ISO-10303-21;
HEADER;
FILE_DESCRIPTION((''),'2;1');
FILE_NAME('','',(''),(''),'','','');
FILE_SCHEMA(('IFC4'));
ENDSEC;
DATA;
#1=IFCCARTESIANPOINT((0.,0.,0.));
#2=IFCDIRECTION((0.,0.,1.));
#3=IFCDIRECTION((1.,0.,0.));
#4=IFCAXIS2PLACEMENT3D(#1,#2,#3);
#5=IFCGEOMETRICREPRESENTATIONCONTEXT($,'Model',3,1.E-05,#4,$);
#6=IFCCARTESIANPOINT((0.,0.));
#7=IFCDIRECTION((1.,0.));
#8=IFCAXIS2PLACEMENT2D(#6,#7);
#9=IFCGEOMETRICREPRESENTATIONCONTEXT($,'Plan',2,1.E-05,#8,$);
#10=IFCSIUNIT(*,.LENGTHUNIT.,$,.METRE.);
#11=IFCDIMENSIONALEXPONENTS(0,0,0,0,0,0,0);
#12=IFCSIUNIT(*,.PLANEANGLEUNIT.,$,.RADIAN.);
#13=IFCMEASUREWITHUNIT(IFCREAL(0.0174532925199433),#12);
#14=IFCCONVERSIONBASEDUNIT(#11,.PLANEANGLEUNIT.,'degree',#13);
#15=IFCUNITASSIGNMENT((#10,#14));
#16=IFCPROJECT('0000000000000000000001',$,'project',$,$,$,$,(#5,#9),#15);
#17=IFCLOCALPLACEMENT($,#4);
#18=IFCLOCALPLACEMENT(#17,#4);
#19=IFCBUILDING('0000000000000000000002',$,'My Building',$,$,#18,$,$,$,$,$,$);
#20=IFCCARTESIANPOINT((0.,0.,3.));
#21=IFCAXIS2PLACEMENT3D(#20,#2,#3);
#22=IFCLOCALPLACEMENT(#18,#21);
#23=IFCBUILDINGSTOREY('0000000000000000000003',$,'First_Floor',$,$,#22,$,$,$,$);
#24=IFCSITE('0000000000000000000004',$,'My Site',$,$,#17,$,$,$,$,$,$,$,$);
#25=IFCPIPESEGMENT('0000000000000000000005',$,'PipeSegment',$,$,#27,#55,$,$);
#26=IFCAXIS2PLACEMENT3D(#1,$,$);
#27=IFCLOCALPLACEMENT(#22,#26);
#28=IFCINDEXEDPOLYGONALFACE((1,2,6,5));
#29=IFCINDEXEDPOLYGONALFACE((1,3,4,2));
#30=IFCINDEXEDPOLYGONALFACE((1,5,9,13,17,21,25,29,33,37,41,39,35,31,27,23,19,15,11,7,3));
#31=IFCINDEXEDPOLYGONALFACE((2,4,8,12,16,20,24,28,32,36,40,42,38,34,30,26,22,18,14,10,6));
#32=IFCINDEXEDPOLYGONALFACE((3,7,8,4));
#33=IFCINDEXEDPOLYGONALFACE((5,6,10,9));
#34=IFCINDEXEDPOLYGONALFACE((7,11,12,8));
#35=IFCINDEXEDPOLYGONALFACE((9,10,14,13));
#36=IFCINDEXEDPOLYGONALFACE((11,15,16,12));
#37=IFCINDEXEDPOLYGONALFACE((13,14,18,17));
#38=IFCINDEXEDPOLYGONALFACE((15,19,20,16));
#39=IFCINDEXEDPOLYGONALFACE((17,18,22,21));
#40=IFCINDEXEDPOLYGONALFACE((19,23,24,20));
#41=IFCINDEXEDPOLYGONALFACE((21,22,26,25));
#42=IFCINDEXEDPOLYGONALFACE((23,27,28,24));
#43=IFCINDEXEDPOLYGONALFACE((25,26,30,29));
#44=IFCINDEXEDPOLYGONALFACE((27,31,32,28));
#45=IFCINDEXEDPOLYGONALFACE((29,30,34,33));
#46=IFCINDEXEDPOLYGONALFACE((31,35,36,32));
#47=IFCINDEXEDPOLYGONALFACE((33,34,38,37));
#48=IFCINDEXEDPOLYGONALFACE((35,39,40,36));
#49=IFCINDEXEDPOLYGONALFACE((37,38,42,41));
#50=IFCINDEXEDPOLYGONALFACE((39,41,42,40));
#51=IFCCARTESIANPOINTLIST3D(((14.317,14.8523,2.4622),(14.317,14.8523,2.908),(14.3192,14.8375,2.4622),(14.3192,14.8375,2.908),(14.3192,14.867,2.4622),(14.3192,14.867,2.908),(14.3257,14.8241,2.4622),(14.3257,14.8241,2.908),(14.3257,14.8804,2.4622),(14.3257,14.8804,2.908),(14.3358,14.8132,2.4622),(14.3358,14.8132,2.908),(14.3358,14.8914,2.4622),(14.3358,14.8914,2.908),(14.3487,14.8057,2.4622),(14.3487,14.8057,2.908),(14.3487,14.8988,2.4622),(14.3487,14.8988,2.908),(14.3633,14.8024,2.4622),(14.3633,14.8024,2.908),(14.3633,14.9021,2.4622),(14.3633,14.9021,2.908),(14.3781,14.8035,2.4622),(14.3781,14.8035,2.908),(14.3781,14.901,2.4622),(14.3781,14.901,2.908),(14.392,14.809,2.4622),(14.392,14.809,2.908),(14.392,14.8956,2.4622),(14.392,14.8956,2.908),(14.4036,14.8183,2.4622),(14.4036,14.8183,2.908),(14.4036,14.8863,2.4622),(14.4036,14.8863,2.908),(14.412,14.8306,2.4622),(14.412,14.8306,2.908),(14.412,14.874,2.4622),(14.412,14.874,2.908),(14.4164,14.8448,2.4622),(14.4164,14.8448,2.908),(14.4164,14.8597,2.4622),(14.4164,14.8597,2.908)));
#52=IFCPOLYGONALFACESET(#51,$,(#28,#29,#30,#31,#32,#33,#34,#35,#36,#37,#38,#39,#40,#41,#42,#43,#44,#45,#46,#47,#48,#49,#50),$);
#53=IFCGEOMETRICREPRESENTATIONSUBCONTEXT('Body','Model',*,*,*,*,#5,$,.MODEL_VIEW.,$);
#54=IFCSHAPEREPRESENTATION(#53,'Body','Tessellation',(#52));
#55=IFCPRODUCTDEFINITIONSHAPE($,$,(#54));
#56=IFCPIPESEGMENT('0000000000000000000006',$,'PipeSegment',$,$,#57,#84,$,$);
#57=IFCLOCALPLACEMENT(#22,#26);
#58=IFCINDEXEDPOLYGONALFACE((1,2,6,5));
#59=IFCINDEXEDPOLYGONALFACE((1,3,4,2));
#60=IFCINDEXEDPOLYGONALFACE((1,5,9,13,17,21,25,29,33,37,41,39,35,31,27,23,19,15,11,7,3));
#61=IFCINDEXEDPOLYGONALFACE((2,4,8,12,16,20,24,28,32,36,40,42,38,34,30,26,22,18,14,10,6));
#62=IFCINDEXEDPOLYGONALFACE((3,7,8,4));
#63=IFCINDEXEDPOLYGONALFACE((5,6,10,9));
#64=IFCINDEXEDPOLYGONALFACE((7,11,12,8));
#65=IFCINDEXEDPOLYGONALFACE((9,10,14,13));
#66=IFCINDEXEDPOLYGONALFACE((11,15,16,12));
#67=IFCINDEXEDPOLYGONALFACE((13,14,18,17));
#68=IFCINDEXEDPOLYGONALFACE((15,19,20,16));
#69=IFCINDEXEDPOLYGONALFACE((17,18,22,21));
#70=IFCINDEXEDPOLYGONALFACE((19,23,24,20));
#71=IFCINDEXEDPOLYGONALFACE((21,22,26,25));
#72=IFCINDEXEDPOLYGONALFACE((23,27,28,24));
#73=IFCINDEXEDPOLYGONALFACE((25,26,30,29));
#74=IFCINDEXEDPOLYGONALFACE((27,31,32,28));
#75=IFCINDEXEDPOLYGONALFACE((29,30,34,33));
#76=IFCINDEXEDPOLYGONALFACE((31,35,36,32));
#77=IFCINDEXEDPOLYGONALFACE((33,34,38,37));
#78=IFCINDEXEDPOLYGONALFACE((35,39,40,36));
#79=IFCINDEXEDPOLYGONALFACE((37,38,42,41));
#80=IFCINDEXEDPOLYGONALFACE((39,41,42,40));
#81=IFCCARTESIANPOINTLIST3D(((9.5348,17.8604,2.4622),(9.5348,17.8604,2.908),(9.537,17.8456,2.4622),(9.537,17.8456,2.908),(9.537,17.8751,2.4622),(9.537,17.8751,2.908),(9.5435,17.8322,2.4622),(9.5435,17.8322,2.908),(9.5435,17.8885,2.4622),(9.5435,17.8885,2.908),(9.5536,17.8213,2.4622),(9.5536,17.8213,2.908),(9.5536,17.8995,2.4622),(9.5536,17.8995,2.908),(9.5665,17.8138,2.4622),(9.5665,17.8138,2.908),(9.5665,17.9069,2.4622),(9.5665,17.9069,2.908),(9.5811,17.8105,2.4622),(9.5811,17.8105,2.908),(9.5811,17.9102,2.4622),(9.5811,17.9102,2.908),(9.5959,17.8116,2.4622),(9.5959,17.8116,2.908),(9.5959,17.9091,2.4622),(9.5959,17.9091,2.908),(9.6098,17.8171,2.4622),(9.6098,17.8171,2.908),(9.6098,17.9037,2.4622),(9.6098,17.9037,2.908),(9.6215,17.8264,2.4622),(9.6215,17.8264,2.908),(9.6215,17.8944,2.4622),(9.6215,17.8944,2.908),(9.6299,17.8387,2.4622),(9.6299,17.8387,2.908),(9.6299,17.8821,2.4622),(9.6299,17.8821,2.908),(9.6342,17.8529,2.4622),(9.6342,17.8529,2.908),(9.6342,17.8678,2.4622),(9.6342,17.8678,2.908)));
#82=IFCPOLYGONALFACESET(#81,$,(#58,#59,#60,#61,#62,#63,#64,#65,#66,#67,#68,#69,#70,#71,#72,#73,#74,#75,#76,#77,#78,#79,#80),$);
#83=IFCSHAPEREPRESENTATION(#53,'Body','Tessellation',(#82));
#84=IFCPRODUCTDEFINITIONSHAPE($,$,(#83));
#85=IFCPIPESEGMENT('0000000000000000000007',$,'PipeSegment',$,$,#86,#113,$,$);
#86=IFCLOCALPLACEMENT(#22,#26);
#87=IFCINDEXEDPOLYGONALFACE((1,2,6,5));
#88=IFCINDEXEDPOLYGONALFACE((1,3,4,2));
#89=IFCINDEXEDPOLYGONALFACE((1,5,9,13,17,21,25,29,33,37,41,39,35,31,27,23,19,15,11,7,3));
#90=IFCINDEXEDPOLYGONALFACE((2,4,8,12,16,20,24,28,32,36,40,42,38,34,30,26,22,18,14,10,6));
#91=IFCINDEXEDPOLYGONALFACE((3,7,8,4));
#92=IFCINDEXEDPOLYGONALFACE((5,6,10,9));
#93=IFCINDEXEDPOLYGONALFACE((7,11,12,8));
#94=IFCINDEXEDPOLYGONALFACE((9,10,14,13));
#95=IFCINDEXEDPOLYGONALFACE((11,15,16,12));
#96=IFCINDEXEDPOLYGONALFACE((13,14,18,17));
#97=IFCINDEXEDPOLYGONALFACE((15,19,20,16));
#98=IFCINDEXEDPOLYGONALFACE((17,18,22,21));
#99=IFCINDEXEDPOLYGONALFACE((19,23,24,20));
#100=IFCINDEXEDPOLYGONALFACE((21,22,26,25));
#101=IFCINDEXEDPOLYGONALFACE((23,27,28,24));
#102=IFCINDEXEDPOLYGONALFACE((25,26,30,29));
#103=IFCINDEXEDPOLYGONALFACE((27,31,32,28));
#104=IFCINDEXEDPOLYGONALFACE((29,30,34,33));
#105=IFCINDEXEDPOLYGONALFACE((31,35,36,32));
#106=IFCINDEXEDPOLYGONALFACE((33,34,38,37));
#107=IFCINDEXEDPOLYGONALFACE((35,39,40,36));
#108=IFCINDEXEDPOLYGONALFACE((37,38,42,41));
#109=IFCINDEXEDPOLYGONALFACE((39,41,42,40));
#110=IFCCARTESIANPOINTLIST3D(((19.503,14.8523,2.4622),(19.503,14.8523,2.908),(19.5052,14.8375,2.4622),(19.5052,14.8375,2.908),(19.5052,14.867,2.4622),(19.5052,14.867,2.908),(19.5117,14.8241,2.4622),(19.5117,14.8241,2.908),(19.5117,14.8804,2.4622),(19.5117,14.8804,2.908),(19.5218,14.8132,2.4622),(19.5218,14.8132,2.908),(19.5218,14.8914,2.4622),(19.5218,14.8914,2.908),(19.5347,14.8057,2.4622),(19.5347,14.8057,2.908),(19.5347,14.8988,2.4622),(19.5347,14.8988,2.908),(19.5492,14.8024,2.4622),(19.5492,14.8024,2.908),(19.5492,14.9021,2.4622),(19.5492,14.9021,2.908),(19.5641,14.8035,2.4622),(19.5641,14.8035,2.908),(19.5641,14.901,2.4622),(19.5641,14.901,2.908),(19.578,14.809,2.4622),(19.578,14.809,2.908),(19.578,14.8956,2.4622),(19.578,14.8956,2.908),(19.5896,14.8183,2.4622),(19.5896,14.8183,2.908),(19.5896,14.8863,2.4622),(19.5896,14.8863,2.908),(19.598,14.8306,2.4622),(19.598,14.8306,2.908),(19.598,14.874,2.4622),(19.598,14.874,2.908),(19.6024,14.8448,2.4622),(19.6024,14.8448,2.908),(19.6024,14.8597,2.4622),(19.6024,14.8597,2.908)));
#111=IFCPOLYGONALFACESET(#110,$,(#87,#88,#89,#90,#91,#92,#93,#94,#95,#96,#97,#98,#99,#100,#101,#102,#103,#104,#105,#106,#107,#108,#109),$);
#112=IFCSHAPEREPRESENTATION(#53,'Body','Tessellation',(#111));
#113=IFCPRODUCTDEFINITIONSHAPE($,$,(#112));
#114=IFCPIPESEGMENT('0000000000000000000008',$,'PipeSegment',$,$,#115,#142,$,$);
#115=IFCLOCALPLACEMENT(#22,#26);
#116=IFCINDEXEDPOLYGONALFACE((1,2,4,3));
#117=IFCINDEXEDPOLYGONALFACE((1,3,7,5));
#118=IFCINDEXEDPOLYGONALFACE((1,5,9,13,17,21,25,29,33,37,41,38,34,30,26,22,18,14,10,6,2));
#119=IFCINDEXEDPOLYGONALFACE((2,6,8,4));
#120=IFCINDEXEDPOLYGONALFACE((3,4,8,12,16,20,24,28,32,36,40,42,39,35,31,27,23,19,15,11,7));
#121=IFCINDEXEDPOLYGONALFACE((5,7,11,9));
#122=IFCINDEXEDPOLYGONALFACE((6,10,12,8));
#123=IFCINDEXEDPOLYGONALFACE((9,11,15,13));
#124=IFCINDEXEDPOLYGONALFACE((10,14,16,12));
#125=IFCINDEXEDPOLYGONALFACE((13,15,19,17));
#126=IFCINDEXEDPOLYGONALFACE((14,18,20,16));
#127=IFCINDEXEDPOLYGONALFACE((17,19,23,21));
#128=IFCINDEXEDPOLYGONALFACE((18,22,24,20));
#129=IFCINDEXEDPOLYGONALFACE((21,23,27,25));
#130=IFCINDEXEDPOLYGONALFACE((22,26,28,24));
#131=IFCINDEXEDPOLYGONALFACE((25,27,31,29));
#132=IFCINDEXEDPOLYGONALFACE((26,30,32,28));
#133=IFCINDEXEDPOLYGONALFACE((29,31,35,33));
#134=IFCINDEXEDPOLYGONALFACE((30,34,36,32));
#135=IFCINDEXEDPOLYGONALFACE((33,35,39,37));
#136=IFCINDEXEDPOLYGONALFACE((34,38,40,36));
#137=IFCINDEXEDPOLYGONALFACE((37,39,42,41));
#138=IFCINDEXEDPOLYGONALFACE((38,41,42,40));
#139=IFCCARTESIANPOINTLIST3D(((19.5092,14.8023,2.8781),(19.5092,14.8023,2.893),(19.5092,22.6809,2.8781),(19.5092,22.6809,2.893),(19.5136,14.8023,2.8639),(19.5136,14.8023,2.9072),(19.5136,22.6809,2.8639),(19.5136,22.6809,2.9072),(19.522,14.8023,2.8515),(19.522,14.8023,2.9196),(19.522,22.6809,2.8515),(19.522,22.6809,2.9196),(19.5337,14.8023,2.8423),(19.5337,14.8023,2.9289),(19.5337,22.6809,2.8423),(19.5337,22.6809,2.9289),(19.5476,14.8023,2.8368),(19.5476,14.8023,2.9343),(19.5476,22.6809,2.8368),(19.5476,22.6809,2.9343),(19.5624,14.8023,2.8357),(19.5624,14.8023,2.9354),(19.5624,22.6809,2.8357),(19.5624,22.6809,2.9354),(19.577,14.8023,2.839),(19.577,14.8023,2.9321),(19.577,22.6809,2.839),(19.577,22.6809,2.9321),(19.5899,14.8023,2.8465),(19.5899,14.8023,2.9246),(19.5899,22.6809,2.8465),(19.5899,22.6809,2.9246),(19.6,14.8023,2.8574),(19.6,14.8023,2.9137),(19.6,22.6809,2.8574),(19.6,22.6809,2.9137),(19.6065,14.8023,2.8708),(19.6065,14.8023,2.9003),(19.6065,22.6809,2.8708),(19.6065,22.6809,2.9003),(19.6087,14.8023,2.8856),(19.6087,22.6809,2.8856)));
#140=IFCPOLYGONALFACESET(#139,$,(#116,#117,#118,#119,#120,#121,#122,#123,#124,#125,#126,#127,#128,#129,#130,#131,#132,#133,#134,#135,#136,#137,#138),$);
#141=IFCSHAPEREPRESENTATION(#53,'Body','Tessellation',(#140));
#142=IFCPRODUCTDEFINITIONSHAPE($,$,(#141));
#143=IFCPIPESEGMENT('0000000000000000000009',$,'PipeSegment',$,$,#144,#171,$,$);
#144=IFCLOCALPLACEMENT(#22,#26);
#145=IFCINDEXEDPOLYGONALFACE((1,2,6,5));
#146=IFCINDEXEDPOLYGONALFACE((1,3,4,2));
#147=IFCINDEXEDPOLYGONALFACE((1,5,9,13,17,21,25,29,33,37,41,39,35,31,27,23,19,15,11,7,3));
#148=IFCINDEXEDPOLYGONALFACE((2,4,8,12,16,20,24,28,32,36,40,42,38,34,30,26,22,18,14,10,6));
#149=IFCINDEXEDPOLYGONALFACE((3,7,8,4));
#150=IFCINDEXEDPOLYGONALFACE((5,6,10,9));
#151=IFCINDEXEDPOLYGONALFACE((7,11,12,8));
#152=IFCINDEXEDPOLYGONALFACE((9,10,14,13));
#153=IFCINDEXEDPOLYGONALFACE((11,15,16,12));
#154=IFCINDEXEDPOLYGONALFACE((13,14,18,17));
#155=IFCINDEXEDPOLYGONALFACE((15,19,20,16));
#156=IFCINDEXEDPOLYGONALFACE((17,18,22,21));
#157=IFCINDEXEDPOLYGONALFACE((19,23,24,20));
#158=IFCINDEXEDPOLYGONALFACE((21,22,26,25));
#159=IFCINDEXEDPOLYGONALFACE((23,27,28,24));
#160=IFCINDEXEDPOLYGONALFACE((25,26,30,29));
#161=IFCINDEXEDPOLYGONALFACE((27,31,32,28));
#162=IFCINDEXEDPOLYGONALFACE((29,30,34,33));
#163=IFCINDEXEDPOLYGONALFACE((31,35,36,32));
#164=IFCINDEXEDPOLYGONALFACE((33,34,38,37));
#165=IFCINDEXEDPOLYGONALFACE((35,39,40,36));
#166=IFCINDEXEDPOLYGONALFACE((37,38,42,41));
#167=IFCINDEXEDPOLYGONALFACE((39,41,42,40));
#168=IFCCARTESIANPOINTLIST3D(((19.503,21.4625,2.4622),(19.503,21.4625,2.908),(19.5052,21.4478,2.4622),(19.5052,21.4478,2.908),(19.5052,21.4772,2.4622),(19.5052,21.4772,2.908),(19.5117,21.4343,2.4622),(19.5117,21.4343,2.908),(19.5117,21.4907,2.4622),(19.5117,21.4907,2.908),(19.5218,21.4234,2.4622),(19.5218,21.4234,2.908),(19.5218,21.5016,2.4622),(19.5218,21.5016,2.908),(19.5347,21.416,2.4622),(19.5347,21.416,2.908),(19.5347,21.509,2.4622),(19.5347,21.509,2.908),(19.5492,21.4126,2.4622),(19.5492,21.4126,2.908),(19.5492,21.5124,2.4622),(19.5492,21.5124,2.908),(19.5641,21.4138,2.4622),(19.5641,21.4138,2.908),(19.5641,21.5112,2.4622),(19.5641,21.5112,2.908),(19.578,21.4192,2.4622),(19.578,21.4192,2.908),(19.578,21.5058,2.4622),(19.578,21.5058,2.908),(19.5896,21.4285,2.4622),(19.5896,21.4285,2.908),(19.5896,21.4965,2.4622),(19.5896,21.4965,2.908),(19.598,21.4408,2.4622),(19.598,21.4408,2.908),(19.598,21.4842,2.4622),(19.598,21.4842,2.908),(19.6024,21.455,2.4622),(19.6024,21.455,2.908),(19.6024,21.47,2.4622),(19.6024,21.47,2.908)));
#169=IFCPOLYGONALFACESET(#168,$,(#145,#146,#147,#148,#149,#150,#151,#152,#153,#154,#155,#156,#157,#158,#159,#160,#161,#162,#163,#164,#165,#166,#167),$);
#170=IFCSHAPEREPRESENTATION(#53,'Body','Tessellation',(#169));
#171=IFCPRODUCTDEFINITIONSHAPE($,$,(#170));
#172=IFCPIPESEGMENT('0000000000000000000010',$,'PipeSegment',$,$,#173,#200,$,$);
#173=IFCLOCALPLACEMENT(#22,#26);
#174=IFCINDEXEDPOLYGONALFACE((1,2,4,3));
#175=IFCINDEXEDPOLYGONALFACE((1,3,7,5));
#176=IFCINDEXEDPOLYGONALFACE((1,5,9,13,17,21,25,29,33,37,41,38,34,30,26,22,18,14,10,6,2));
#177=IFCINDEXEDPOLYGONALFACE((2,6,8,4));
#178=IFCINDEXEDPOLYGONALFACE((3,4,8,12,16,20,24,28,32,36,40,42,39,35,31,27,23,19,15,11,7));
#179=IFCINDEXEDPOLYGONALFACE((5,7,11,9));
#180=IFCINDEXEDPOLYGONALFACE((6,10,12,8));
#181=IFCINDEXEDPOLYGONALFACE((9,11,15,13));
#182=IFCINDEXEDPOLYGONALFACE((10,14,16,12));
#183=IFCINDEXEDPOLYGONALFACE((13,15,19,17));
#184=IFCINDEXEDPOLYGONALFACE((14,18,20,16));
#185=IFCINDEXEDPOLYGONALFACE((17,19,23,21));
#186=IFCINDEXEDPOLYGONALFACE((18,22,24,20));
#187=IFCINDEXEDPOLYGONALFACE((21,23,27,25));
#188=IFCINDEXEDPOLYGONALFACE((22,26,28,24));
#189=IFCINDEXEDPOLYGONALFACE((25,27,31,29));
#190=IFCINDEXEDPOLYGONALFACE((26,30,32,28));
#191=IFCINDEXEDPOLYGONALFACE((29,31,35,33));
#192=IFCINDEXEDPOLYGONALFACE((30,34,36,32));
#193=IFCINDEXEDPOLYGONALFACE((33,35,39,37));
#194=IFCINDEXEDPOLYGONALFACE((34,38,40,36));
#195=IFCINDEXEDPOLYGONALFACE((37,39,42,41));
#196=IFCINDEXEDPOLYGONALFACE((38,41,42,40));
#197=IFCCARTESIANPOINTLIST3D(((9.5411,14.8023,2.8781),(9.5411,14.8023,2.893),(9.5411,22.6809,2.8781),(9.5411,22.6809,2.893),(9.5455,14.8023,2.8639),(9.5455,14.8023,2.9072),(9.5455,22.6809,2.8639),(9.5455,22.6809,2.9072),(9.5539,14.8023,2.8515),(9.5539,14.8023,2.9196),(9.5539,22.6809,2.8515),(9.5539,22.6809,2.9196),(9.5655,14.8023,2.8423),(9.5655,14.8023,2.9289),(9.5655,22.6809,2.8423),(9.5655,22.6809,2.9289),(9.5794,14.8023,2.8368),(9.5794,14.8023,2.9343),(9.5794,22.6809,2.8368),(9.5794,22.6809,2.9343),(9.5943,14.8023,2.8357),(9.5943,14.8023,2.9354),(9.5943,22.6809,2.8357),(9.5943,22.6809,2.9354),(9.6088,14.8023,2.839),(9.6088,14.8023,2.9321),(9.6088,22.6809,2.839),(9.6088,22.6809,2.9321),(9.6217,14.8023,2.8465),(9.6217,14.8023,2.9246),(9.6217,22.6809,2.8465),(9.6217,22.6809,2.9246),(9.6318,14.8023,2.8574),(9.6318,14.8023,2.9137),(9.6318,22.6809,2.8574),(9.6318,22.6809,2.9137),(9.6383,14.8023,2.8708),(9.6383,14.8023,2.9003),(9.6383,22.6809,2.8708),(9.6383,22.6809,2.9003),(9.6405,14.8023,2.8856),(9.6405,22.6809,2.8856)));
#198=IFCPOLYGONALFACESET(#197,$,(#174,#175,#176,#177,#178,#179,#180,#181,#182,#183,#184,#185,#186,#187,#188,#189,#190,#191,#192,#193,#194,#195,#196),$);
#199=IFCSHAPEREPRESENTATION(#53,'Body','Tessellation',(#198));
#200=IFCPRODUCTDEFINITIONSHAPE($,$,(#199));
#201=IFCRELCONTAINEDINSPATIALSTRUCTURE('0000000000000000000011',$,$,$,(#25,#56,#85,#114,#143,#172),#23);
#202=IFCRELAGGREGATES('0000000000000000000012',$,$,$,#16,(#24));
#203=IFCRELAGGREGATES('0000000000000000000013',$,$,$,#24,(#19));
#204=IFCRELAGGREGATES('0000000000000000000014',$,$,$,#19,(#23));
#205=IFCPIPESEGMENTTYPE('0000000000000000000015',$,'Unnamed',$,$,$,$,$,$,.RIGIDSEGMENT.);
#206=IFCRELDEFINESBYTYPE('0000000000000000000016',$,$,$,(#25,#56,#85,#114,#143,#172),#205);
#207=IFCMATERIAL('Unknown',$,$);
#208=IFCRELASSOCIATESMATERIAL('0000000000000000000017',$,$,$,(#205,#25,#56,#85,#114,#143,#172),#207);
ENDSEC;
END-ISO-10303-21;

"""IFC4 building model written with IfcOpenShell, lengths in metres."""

from ifc_helpers import new_model, entity, si_unit, converted_unit, frame, origin_with_axes, origin_2d_with_axis, place, context, subcontext, project, spatial, circle, extrude, material, material_profile, profile_set, profile_usage, type_object, element, save


model = new_model("IFC4")

# Units and contexts
model_context = context("Model", 3, precision=1e-05, world=origin_with_axes())
plan_context = context("Plan", 2, precision=1e-05, world=origin_2d_with_axis())
body_context = subcontext(model_context, "Body", "Model", "MODEL_VIEW")
ifc_project = project(units=[si_unit("LENGTHUNIT", "METRE"), converted_unit("PLANEANGLEUNIT", "degree", entity("IfcReal", 0.0174532925199433), si_unit("PLANEANGLEUNIT", "RADIAN"), dimensions=[0, 0, 0, 0, 0, 0, 0])], contexts=[model_context, plan_context])

# Site, building, storey
site_placement = place(None, origin_with_axes())
site = spatial("IfcSite", under=ifc_project, at=site_placement, Name="My Site")
building_placement = place(site_placement, origin_with_axes())
building = spatial("IfcBuilding", under=site, at=building_placement, Name="My Building")
storey_placement = place(building_placement, frame((0.0, 0.0, 3.0), z_axis=(0.0, 0.0, 1.0), x_axis=(1.0, 0.0, 0.0)))
storey = spatial("IfcBuildingStorey", under=building, at=storey_placement, Name="First_Floor")

# Shared definitions
ifc_material = material(Name="Unknown")

# Pipe segments
ifc_material_profile_1 = material_profile(ifc_material, circle(Radius=0.05))
ifc_profile_set_1 = profile_set([ifc_material_profile_1])
pipe_segment_type = type_object("IfcPipeSegmentType", Name="Unnamed", PredefinedType="RIGIDSEGMENT", material=ifc_profile_set_1)
ifc_profile_usage_1 = profile_usage(ifc_profile_set_1, cardinal=5)
pipe_segment_1_placement = place(storey_placement, frame((14.367, 14.8523, 2.908), z_axis=(0.0, 0.0, -1.0), x_axis=(-1.0, 0.0, 0.0)))
element("IfcPipeSegment", 1, at=pipe_segment_1_placement, inside=storey, type_object=pipe_segment_type, material=ifc_profile_usage_1, Name="PipeSegment", context=body_context, shape_type="SweptSolid", body=[
    extrude(circle(Radius=0.05), origin_with_axes(), (0.0, 0.0, 1.0), 0.4458),
])
ifc_profile_usage_2 = profile_usage(ifc_profile_set_1, cardinal=5)
pipe_segment_2_placement = place(storey_placement, frame((9.5848, 17.8604, 2.908), z_axis=(0.0, 0.0, -1.0), x_axis=(-1.0, 0.0, 0.0)))
element("IfcPipeSegment", 2, at=pipe_segment_2_placement, inside=storey, type_object=pipe_segment_type, material=ifc_profile_usage_2, Name="PipeSegment", context=body_context, shape_type="SweptSolid", body=[
    extrude(circle(Radius=0.05), origin_with_axes(), (0.0, 0.0, 1.0), 0.4458),
])
ifc_profile_usage_3 = profile_usage(ifc_profile_set_1, cardinal=5)
pipe_segment_3_placement = place(storey_placement, frame((19.553, 14.8523, 2.908), z_axis=(0.0, 0.0, -1.0), x_axis=(-1.0, 0.0, 0.0)))
element("IfcPipeSegment", 3, at=pipe_segment_3_placement, inside=storey, type_object=pipe_segment_type, material=ifc_profile_usage_3, Name="PipeSegment", context=body_context, shape_type="SweptSolid", body=[
    extrude(circle(Radius=0.05), origin_with_axes(), (0.0, 0.0, 1.0), 0.4458),
])
ifc_profile_usage_4 = profile_usage(ifc_profile_set_1, cardinal=5)
pipe_segment_4_placement = place(storey_placement, frame((19.5587, 22.6809, 2.8856), z_axis=(0.0, -1.0, 0.0), x_axis=(1.0, 0.0, 0.0)))
element("IfcPipeSegment", 4, at=pipe_segment_4_placement, inside=storey, type_object=pipe_segment_type, material=ifc_profile_usage_4, Name="PipeSegment", context=body_context, shape_type="SweptSolid", body=[
    extrude(circle(Radius=0.05), origin_with_axes(), (0.0, 0.0, 1.0), 7.8786),
])
ifc_profile_usage_5 = profile_usage(ifc_profile_set_1, cardinal=5)
pipe_segment_5_placement = place(storey_placement, frame((19.553, 21.4625, 2.908), z_axis=(0.0, 0.0, -1.0), x_axis=(-1.0, 0.0, 0.0)))
element("IfcPipeSegment", 5, at=pipe_segment_5_placement, inside=storey, type_object=pipe_segment_type, material=ifc_profile_usage_5, Name="PipeSegment", context=body_context, shape_type="SweptSolid", body=[
    extrude(circle(Radius=0.05), origin_with_axes(), (0.0, 0.0, 1.0), 0.4458),
])
ifc_profile_usage_6 = profile_usage(ifc_profile_set_1, cardinal=5)
pipe_segment_6_placement = place(storey_placement, frame((9.5905, 22.6809, 2.8856), z_axis=(0.0, -1.0, 0.0), x_axis=(1.0, 0.0, 0.0)))
element("IfcPipeSegment", 6, at=pipe_segment_6_placement, inside=storey, type_object=pipe_segment_type, material=ifc_profile_usage_6, Name="PipeSegment", context=body_context, shape_type="SweptSolid", body=[
    extrude(circle(Radius=0.05), origin_with_axes(), (0.0, 0.0, 1.0), 7.8786),
])

save(model, "model.ifc")
